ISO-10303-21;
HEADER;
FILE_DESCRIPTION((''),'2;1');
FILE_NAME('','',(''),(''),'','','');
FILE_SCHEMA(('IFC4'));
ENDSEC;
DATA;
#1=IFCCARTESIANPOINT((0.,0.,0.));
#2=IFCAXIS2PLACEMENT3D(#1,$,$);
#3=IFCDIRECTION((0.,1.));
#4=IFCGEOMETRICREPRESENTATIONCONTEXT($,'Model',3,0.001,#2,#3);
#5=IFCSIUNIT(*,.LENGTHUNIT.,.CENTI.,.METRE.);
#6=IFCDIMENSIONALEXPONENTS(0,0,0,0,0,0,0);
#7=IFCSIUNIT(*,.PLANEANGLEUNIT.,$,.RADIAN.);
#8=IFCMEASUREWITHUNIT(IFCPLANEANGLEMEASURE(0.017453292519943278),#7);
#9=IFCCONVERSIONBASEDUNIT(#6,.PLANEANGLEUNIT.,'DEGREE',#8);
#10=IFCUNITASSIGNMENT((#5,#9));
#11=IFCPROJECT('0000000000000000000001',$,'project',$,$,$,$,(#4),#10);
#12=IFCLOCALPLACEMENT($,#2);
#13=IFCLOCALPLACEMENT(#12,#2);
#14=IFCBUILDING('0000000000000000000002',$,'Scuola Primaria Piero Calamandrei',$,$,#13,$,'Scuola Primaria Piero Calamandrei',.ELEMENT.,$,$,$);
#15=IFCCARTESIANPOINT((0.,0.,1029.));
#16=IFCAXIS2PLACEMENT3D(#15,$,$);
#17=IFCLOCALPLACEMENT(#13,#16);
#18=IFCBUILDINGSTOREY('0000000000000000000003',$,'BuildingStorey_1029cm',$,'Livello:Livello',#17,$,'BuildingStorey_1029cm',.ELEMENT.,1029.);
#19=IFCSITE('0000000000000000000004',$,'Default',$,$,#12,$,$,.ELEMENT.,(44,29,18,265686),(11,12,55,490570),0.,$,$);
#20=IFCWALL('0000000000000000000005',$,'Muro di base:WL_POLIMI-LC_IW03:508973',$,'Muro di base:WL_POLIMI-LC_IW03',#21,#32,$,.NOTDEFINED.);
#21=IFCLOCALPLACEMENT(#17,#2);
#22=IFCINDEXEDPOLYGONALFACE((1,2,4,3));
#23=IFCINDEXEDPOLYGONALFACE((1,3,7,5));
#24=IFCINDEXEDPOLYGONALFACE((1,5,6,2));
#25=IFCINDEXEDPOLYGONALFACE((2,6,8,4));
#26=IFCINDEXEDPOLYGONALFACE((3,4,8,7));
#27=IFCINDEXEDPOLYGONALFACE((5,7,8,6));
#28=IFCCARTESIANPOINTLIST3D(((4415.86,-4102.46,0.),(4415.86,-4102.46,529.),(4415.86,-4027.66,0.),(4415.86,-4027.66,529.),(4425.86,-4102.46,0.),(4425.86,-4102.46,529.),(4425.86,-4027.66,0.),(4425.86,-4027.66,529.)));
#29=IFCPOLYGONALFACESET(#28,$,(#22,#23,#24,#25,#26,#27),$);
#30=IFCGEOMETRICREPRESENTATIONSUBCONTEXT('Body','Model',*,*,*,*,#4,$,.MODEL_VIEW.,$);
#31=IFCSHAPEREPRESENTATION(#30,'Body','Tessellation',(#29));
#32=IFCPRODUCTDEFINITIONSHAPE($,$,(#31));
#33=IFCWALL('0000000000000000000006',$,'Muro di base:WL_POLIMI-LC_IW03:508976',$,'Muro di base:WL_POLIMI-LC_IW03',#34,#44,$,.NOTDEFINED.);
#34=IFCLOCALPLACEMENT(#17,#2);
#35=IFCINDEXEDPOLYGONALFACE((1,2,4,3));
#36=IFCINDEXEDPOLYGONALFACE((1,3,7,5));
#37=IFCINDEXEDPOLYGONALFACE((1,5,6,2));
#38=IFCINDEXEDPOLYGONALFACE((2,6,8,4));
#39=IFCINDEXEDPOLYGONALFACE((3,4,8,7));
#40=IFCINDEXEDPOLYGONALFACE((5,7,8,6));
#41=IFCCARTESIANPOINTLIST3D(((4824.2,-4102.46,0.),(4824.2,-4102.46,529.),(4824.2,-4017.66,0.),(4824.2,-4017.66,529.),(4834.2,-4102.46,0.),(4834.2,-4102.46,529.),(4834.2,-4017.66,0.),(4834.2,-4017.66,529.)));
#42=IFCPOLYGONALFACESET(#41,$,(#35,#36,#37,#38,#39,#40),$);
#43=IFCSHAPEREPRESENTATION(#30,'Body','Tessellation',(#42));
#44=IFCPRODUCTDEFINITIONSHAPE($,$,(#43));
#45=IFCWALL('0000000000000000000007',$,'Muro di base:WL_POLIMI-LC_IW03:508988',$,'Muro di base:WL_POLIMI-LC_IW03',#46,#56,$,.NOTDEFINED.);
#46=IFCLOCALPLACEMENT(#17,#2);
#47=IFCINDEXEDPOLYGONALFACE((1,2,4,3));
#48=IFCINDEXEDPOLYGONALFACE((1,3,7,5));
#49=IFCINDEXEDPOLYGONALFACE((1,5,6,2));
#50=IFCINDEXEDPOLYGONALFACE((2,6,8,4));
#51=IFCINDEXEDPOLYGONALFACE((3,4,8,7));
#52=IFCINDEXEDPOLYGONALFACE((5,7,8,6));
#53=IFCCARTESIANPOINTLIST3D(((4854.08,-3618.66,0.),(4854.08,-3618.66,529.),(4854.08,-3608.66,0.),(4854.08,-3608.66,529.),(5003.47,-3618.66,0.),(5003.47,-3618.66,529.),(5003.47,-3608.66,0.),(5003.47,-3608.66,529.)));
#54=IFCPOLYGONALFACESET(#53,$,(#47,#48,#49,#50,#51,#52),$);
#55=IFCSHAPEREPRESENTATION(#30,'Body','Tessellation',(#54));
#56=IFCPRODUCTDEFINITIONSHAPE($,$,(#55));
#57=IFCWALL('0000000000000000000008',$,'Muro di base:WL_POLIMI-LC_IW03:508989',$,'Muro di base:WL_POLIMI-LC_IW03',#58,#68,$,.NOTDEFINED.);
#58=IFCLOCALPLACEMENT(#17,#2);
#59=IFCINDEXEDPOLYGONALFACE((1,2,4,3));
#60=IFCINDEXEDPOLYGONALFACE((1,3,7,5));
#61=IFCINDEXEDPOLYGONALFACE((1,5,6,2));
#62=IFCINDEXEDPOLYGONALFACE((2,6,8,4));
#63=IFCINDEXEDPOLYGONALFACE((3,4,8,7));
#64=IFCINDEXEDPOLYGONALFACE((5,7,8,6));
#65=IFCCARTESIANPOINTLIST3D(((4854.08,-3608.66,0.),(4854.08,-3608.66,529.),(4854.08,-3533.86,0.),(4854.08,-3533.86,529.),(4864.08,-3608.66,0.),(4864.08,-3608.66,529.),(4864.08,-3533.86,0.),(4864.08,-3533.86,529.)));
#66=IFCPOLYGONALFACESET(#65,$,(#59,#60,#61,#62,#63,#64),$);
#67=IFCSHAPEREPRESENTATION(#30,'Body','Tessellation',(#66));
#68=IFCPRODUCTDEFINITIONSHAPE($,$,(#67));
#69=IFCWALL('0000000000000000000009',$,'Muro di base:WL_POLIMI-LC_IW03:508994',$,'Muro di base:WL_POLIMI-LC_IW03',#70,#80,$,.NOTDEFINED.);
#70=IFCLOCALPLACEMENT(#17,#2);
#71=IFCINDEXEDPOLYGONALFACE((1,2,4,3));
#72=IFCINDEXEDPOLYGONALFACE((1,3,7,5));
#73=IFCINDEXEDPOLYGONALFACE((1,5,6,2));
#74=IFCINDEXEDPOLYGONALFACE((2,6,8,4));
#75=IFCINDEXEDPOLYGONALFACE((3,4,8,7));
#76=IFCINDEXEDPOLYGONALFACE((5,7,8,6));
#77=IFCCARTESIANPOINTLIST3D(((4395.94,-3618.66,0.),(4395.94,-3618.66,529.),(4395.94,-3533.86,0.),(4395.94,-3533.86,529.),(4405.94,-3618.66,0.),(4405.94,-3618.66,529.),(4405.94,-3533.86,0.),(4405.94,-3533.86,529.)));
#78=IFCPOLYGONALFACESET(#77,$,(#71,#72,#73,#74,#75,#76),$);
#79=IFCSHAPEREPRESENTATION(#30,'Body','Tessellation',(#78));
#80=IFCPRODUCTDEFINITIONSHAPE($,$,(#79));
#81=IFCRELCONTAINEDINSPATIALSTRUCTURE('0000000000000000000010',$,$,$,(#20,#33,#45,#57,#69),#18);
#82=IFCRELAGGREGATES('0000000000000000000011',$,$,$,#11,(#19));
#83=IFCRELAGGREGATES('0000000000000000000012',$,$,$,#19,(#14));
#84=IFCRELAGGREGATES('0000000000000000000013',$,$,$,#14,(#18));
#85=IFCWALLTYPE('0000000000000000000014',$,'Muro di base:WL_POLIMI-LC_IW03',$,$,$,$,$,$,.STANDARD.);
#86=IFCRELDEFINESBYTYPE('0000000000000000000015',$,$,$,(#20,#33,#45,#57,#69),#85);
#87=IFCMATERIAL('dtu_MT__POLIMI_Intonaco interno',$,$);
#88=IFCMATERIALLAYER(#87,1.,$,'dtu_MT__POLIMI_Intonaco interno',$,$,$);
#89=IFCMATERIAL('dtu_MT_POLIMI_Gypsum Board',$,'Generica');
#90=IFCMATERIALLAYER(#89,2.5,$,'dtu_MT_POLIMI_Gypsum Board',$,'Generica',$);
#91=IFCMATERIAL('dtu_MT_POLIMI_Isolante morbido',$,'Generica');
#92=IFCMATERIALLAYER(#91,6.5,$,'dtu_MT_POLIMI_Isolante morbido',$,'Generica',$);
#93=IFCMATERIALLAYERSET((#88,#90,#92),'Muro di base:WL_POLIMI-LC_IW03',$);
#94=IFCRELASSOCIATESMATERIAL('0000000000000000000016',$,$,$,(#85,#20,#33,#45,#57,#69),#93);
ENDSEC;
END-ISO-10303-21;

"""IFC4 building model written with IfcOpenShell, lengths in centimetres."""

from ifc_helpers import new_model, entity, si_unit, converted_unit, direction, frame, frame_2d, origin, place, context, subcontext, project, spatial, rectangle, extrude, material, layer, layer_set, layer_usage, type_object, element, save


model = new_model("IFC4")

# Units and contexts
model_context = context("Model", 3, precision=0.001, world=origin(), true_north=direction((0.0, 1.0)))
body_context = subcontext(model_context, "Body", "Model", "MODEL_VIEW")
ifc_project = project(units=[si_unit("LENGTHUNIT", "METRE", prefix="CENTI"), converted_unit("PLANEANGLEUNIT", "DEGREE", entity("IfcPlaneAngleMeasure", 0.017453292519943278), si_unit("PLANEANGLEUNIT", "RADIAN"), dimensions=[0, 0, 0, 0, 0, 0, 0])], contexts=[model_context])

# Site, building, storey
site_placement = place(None, origin())
site = spatial("IfcSite", under=ifc_project, at=site_placement, Name="Default", CompositionType="ELEMENT", RefLatitude=(44, 29, 18, 265686), RefLongitude=(11, 12, 55, 490570), RefElevation=0.0)
building_placement = place(site_placement, origin())
building = spatial("IfcBuilding", under=site, at=building_placement, Name="Scuola Primaria Piero Calamandrei", LongName="Scuola Primaria Piero Calamandrei", CompositionType="ELEMENT")
storey_placement = place(building_placement, frame((0.0, 0.0, 1029.0)))
storey = spatial("IfcBuildingStorey", under=building, at=storey_placement, Name="BuildingStorey_1029cm", ObjectType="Livello:Livello", LongName="BuildingStorey_1029cm", CompositionType="ELEMENT", Elevation=1029.0)

# Shared definitions
ifc_material_1 = material(Name="dtu_MT_POLIMI_Isolante morbido", Category="Generica")
ifc_material_2 = material(Name="dtu_MT_POLIMI_Gypsum Board", Category="Generica")
ifc_material_3 = material(Name="dtu_MT__POLIMI_Intonaco interno")

# Walls
ifc_layer_1 = layer(ifc_material_3, 1.0, Name="dtu_MT__POLIMI_Intonaco interno")
ifc_layer_2 = layer(ifc_material_2, 2.5, Name="dtu_MT_POLIMI_Gypsum Board", Category="Generica")
ifc_layer_3 = layer(ifc_material_1, 6.5, Name="dtu_MT_POLIMI_Isolante morbido", Category="Generica")
ifc_layer_set_1 = layer_set([ifc_layer_1, ifc_layer_2, ifc_layer_3], Name="Muro di base:WL_POLIMI-LC_IW03")
wall_type_1 = type_object("IfcWallType", Name="Muro di base:WL_POLIMI-LC_IW03", PredefinedType="STANDARD", material=ifc_layer_set_1)
ifc_layer_usage_1 = layer_usage(ifc_layer_set_1, "AXIS2", "NEGATIVE", 5.0)
wall_1_placement = place(storey_placement, frame((4420.86, -4102.46, 0.0), z_axis=(0.0, 0.0, 1.0), x_axis=(0.0, 1.0, 0.0)))
element("IfcWall", 1, at=wall_1_placement, inside=storey, type_object=wall_type_1, material=ifc_layer_usage_1, Name="Muro di base:WL_POLIMI-LC_IW03:508973", ObjectType="Muro di base:WL_POLIMI-LC_IW03", PredefinedType="NOTDEFINED", context=body_context, shape_type="SweptSolid", body=[
    extrude(rectangle(XDim=74.8, YDim=10.0, at=frame_2d((37.4, 0.0), x_axis=(-1.0, 0.0))), origin(), (0.0, 0.0, 1.0), 529.0),
])
ifc_layer_usage_2 = layer_usage(ifc_layer_set_1, "AXIS2", "NEGATIVE", 5.0)
wall_2_placement = place(storey_placement, frame((4829.2, -4017.66, 0.0), z_axis=(0.0, 0.0, 1.0), x_axis=(0.0, -1.0, 0.0)))
element("IfcWall", 2, at=wall_2_placement, inside=storey, type_object=wall_type_1, material=ifc_layer_usage_2, Name="Muro di base:WL_POLIMI-LC_IW03:508976", ObjectType="Muro di base:WL_POLIMI-LC_IW03", PredefinedType="NOTDEFINED", context=body_context, shape_type="SweptSolid", body=[
    extrude(rectangle(XDim=84.8, YDim=10.0, at=frame_2d((42.4, 0.0), x_axis=(-1.0, 0.0))), origin(), (0.0, 0.0, 1.0), 529.0),
])
ifc_layer_usage_3 = layer_usage(ifc_layer_set_1, "AXIS2", "NEGATIVE", 5.0)
wall_3_placement = place(storey_placement, frame((4854.08, -3613.66, 0.0)))
element("IfcWall", 3, at=wall_3_placement, inside=storey, type_object=wall_type_1, material=ifc_layer_usage_3, Name="Muro di base:WL_POLIMI-LC_IW03:508988", ObjectType="Muro di base:WL_POLIMI-LC_IW03", PredefinedType="NOTDEFINED", context=body_context, shape_type="SweptSolid", body=[
    extrude(rectangle(XDim=149.39, YDim=10.0, at=frame_2d((74.7, 0.0), x_axis=(-1.0, 0.0))), origin(), (0.0, 0.0, 1.0), 529.0),
])
ifc_layer_usage_4 = layer_usage(ifc_layer_set_1, "AXIS2", "NEGATIVE", 5.0)
wall_4_placement = place(storey_placement, frame((4859.08, -3533.86, 0.0), z_axis=(0.0, 0.0, 1.0), x_axis=(0.0, -1.0, 0.0)))
element("IfcWall", 4, at=wall_4_placement, inside=storey, type_object=wall_type_1, material=ifc_layer_usage_4, Name="Muro di base:WL_POLIMI-LC_IW03:508989", ObjectType="Muro di base:WL_POLIMI-LC_IW03", PredefinedType="NOTDEFINED", context=body_context, shape_type="SweptSolid", body=[
    extrude(rectangle(XDim=74.8, YDim=10.0, at=frame_2d((37.4, 0.0), x_axis=(-1.0, 0.0))), origin(), (0.0, 0.0, 1.0), 529.0),
])
ifc_layer_usage_5 = layer_usage(ifc_layer_set_1, "AXIS2", "NEGATIVE", 5.0)
wall_5_placement = place(storey_placement, frame((4400.94, -3618.66, 0.0), z_axis=(0.0, 0.0, 1.0), x_axis=(0.0, 1.0, 0.0)))
element("IfcWall", 5, at=wall_5_placement, inside=storey, type_object=wall_type_1, material=ifc_layer_usage_5, Name="Muro di base:WL_POLIMI-LC_IW03:508994", ObjectType="Muro di base:WL_POLIMI-LC_IW03", PredefinedType="NOTDEFINED", context=body_context, shape_type="SweptSolid", body=[
    extrude(rectangle(XDim=84.8, YDim=10.0, at=frame_2d((42.4, 0.0), x_axis=(-1.0, 0.0))), origin(), (0.0, 0.0, 1.0), 529.0),
])

save(model, "model.ifc")
